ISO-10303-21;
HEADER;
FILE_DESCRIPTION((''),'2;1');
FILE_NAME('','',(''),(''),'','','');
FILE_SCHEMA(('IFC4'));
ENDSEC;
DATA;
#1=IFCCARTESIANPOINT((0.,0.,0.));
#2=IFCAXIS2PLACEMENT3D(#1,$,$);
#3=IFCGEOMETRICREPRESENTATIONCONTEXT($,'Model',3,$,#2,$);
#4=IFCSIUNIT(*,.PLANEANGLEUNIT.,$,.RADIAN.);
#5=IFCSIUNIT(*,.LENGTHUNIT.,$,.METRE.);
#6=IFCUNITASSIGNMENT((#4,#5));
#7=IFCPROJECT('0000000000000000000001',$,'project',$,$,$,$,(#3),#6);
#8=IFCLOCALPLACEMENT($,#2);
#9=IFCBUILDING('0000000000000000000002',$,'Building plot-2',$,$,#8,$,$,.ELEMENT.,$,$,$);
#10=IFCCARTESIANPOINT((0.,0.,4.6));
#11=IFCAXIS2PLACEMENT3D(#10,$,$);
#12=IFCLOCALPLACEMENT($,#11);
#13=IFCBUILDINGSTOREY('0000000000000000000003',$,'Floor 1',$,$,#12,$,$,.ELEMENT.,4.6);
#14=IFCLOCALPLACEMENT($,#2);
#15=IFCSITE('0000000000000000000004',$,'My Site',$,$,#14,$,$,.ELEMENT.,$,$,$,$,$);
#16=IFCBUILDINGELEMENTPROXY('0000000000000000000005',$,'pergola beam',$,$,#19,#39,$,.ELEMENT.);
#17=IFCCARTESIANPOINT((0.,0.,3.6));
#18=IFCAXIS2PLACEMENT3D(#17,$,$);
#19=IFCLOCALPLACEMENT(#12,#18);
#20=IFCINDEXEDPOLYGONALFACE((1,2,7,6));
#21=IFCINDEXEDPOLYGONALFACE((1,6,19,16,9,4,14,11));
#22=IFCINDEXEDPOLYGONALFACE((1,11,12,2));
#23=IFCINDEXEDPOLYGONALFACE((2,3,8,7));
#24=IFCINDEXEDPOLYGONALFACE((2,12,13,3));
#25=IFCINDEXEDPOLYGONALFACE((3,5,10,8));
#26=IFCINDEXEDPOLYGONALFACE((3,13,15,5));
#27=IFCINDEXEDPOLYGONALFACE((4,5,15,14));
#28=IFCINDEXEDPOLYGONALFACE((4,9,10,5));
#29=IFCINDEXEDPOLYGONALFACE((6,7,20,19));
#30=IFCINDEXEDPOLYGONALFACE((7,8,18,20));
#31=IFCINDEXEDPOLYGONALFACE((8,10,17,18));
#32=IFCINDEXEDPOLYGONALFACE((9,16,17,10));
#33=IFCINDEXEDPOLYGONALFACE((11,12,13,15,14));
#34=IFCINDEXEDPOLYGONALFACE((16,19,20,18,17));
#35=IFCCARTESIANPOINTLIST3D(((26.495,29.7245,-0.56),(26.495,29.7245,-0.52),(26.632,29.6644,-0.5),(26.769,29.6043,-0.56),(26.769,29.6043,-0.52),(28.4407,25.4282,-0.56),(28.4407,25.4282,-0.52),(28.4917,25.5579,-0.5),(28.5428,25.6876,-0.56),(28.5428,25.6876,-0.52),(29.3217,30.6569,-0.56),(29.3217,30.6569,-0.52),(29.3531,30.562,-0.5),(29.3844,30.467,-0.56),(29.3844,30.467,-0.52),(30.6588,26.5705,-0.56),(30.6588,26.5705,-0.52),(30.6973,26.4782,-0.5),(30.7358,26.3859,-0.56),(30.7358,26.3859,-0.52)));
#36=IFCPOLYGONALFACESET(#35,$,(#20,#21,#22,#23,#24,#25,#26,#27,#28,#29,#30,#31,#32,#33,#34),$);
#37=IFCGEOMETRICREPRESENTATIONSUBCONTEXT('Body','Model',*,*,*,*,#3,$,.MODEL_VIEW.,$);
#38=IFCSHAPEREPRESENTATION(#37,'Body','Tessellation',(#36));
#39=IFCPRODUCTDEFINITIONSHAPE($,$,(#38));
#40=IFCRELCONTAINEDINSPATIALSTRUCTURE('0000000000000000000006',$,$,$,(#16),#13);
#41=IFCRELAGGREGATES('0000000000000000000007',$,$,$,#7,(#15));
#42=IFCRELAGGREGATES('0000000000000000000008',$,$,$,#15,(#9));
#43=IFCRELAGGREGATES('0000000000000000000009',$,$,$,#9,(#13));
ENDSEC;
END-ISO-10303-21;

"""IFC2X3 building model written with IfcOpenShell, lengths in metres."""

from ifc_helpers import new_model, entity, si_unit, frame, origin, place, context, subcontext, project, spatial, element, save


model = new_model("IFC2X3")

# Units and contexts
model_context = context("Model", 3, world=origin())
body_context = subcontext(model_context, "Body", "Model", "MODEL_VIEW")
ifc_project = project(units=[si_unit("PLANEANGLEUNIT", "RADIAN"), si_unit("LENGTHUNIT", "METRE")], contexts=[model_context])

# Site, building, storey
site_placement = place(None, origin())
site = spatial("IfcSite", under=ifc_project, at=site_placement, Name="My Site", CompositionType="ELEMENT")
building_placement = place(None, origin())
building = spatial("IfcBuilding", under=site, at=building_placement, Name="Building plot-2", CompositionType="ELEMENT")
storey_placement = place(None, frame((0.0, 0.0, 4.6)))
storey = spatial("IfcBuildingStorey", under=building, at=storey_placement, Name="Floor 1", CompositionType="ELEMENT", Elevation=4.6)

# Building element proxy
proxy_1_placement = place(storey_placement, frame((0.0, 0.0, 3.6)))
axis2_placement3_d_1 = entity("IfcAxis2Placement3D", entity("IfcCartesianPoint", [0.0, 0.0, 0.0]))
element("IfcBuildingElementProxy", 1, at=proxy_1_placement, inside=storey, Name="pergola beam", CompositionType="ELEMENT", context=body_context, shape_type="SweptSolid", held_by="IfcProductRepresentation", body=[
    entity("IfcSurfaceCurveSweptAreaSolid", entity("IfcArbitraryClosedProfileDef", "AREA", None, entity("IfcPolyline", [entity("IfcCartesianPoint", [-0.5, 0.0]), entity("IfcCartesianPoint", [-0.52, -0.1]), entity("IfcCartesianPoint", [-0.56, -0.1]), entity("IfcCartesianPoint", [-0.56, 0.1]), entity("IfcCartesianPoint", [-0.52, 0.1]), entity("IfcCartesianPoint", [-0.5, 0.0])])), axis2_placement3_d_1, entity("IfcPolyline", [entity("IfcCartesianPoint", [29.3531, 30.562]), entity("IfcCartesianPoint", [26.632, 29.6644]), entity("IfcCartesianPoint", [28.4917, 25.5579]), entity("IfcCartesianPoint", [30.6973, 26.4782])]), 0.0, 1.0, entity("IfcPlane", axis2_placement3_d_1)),
])

save(model, "model.ifc")
